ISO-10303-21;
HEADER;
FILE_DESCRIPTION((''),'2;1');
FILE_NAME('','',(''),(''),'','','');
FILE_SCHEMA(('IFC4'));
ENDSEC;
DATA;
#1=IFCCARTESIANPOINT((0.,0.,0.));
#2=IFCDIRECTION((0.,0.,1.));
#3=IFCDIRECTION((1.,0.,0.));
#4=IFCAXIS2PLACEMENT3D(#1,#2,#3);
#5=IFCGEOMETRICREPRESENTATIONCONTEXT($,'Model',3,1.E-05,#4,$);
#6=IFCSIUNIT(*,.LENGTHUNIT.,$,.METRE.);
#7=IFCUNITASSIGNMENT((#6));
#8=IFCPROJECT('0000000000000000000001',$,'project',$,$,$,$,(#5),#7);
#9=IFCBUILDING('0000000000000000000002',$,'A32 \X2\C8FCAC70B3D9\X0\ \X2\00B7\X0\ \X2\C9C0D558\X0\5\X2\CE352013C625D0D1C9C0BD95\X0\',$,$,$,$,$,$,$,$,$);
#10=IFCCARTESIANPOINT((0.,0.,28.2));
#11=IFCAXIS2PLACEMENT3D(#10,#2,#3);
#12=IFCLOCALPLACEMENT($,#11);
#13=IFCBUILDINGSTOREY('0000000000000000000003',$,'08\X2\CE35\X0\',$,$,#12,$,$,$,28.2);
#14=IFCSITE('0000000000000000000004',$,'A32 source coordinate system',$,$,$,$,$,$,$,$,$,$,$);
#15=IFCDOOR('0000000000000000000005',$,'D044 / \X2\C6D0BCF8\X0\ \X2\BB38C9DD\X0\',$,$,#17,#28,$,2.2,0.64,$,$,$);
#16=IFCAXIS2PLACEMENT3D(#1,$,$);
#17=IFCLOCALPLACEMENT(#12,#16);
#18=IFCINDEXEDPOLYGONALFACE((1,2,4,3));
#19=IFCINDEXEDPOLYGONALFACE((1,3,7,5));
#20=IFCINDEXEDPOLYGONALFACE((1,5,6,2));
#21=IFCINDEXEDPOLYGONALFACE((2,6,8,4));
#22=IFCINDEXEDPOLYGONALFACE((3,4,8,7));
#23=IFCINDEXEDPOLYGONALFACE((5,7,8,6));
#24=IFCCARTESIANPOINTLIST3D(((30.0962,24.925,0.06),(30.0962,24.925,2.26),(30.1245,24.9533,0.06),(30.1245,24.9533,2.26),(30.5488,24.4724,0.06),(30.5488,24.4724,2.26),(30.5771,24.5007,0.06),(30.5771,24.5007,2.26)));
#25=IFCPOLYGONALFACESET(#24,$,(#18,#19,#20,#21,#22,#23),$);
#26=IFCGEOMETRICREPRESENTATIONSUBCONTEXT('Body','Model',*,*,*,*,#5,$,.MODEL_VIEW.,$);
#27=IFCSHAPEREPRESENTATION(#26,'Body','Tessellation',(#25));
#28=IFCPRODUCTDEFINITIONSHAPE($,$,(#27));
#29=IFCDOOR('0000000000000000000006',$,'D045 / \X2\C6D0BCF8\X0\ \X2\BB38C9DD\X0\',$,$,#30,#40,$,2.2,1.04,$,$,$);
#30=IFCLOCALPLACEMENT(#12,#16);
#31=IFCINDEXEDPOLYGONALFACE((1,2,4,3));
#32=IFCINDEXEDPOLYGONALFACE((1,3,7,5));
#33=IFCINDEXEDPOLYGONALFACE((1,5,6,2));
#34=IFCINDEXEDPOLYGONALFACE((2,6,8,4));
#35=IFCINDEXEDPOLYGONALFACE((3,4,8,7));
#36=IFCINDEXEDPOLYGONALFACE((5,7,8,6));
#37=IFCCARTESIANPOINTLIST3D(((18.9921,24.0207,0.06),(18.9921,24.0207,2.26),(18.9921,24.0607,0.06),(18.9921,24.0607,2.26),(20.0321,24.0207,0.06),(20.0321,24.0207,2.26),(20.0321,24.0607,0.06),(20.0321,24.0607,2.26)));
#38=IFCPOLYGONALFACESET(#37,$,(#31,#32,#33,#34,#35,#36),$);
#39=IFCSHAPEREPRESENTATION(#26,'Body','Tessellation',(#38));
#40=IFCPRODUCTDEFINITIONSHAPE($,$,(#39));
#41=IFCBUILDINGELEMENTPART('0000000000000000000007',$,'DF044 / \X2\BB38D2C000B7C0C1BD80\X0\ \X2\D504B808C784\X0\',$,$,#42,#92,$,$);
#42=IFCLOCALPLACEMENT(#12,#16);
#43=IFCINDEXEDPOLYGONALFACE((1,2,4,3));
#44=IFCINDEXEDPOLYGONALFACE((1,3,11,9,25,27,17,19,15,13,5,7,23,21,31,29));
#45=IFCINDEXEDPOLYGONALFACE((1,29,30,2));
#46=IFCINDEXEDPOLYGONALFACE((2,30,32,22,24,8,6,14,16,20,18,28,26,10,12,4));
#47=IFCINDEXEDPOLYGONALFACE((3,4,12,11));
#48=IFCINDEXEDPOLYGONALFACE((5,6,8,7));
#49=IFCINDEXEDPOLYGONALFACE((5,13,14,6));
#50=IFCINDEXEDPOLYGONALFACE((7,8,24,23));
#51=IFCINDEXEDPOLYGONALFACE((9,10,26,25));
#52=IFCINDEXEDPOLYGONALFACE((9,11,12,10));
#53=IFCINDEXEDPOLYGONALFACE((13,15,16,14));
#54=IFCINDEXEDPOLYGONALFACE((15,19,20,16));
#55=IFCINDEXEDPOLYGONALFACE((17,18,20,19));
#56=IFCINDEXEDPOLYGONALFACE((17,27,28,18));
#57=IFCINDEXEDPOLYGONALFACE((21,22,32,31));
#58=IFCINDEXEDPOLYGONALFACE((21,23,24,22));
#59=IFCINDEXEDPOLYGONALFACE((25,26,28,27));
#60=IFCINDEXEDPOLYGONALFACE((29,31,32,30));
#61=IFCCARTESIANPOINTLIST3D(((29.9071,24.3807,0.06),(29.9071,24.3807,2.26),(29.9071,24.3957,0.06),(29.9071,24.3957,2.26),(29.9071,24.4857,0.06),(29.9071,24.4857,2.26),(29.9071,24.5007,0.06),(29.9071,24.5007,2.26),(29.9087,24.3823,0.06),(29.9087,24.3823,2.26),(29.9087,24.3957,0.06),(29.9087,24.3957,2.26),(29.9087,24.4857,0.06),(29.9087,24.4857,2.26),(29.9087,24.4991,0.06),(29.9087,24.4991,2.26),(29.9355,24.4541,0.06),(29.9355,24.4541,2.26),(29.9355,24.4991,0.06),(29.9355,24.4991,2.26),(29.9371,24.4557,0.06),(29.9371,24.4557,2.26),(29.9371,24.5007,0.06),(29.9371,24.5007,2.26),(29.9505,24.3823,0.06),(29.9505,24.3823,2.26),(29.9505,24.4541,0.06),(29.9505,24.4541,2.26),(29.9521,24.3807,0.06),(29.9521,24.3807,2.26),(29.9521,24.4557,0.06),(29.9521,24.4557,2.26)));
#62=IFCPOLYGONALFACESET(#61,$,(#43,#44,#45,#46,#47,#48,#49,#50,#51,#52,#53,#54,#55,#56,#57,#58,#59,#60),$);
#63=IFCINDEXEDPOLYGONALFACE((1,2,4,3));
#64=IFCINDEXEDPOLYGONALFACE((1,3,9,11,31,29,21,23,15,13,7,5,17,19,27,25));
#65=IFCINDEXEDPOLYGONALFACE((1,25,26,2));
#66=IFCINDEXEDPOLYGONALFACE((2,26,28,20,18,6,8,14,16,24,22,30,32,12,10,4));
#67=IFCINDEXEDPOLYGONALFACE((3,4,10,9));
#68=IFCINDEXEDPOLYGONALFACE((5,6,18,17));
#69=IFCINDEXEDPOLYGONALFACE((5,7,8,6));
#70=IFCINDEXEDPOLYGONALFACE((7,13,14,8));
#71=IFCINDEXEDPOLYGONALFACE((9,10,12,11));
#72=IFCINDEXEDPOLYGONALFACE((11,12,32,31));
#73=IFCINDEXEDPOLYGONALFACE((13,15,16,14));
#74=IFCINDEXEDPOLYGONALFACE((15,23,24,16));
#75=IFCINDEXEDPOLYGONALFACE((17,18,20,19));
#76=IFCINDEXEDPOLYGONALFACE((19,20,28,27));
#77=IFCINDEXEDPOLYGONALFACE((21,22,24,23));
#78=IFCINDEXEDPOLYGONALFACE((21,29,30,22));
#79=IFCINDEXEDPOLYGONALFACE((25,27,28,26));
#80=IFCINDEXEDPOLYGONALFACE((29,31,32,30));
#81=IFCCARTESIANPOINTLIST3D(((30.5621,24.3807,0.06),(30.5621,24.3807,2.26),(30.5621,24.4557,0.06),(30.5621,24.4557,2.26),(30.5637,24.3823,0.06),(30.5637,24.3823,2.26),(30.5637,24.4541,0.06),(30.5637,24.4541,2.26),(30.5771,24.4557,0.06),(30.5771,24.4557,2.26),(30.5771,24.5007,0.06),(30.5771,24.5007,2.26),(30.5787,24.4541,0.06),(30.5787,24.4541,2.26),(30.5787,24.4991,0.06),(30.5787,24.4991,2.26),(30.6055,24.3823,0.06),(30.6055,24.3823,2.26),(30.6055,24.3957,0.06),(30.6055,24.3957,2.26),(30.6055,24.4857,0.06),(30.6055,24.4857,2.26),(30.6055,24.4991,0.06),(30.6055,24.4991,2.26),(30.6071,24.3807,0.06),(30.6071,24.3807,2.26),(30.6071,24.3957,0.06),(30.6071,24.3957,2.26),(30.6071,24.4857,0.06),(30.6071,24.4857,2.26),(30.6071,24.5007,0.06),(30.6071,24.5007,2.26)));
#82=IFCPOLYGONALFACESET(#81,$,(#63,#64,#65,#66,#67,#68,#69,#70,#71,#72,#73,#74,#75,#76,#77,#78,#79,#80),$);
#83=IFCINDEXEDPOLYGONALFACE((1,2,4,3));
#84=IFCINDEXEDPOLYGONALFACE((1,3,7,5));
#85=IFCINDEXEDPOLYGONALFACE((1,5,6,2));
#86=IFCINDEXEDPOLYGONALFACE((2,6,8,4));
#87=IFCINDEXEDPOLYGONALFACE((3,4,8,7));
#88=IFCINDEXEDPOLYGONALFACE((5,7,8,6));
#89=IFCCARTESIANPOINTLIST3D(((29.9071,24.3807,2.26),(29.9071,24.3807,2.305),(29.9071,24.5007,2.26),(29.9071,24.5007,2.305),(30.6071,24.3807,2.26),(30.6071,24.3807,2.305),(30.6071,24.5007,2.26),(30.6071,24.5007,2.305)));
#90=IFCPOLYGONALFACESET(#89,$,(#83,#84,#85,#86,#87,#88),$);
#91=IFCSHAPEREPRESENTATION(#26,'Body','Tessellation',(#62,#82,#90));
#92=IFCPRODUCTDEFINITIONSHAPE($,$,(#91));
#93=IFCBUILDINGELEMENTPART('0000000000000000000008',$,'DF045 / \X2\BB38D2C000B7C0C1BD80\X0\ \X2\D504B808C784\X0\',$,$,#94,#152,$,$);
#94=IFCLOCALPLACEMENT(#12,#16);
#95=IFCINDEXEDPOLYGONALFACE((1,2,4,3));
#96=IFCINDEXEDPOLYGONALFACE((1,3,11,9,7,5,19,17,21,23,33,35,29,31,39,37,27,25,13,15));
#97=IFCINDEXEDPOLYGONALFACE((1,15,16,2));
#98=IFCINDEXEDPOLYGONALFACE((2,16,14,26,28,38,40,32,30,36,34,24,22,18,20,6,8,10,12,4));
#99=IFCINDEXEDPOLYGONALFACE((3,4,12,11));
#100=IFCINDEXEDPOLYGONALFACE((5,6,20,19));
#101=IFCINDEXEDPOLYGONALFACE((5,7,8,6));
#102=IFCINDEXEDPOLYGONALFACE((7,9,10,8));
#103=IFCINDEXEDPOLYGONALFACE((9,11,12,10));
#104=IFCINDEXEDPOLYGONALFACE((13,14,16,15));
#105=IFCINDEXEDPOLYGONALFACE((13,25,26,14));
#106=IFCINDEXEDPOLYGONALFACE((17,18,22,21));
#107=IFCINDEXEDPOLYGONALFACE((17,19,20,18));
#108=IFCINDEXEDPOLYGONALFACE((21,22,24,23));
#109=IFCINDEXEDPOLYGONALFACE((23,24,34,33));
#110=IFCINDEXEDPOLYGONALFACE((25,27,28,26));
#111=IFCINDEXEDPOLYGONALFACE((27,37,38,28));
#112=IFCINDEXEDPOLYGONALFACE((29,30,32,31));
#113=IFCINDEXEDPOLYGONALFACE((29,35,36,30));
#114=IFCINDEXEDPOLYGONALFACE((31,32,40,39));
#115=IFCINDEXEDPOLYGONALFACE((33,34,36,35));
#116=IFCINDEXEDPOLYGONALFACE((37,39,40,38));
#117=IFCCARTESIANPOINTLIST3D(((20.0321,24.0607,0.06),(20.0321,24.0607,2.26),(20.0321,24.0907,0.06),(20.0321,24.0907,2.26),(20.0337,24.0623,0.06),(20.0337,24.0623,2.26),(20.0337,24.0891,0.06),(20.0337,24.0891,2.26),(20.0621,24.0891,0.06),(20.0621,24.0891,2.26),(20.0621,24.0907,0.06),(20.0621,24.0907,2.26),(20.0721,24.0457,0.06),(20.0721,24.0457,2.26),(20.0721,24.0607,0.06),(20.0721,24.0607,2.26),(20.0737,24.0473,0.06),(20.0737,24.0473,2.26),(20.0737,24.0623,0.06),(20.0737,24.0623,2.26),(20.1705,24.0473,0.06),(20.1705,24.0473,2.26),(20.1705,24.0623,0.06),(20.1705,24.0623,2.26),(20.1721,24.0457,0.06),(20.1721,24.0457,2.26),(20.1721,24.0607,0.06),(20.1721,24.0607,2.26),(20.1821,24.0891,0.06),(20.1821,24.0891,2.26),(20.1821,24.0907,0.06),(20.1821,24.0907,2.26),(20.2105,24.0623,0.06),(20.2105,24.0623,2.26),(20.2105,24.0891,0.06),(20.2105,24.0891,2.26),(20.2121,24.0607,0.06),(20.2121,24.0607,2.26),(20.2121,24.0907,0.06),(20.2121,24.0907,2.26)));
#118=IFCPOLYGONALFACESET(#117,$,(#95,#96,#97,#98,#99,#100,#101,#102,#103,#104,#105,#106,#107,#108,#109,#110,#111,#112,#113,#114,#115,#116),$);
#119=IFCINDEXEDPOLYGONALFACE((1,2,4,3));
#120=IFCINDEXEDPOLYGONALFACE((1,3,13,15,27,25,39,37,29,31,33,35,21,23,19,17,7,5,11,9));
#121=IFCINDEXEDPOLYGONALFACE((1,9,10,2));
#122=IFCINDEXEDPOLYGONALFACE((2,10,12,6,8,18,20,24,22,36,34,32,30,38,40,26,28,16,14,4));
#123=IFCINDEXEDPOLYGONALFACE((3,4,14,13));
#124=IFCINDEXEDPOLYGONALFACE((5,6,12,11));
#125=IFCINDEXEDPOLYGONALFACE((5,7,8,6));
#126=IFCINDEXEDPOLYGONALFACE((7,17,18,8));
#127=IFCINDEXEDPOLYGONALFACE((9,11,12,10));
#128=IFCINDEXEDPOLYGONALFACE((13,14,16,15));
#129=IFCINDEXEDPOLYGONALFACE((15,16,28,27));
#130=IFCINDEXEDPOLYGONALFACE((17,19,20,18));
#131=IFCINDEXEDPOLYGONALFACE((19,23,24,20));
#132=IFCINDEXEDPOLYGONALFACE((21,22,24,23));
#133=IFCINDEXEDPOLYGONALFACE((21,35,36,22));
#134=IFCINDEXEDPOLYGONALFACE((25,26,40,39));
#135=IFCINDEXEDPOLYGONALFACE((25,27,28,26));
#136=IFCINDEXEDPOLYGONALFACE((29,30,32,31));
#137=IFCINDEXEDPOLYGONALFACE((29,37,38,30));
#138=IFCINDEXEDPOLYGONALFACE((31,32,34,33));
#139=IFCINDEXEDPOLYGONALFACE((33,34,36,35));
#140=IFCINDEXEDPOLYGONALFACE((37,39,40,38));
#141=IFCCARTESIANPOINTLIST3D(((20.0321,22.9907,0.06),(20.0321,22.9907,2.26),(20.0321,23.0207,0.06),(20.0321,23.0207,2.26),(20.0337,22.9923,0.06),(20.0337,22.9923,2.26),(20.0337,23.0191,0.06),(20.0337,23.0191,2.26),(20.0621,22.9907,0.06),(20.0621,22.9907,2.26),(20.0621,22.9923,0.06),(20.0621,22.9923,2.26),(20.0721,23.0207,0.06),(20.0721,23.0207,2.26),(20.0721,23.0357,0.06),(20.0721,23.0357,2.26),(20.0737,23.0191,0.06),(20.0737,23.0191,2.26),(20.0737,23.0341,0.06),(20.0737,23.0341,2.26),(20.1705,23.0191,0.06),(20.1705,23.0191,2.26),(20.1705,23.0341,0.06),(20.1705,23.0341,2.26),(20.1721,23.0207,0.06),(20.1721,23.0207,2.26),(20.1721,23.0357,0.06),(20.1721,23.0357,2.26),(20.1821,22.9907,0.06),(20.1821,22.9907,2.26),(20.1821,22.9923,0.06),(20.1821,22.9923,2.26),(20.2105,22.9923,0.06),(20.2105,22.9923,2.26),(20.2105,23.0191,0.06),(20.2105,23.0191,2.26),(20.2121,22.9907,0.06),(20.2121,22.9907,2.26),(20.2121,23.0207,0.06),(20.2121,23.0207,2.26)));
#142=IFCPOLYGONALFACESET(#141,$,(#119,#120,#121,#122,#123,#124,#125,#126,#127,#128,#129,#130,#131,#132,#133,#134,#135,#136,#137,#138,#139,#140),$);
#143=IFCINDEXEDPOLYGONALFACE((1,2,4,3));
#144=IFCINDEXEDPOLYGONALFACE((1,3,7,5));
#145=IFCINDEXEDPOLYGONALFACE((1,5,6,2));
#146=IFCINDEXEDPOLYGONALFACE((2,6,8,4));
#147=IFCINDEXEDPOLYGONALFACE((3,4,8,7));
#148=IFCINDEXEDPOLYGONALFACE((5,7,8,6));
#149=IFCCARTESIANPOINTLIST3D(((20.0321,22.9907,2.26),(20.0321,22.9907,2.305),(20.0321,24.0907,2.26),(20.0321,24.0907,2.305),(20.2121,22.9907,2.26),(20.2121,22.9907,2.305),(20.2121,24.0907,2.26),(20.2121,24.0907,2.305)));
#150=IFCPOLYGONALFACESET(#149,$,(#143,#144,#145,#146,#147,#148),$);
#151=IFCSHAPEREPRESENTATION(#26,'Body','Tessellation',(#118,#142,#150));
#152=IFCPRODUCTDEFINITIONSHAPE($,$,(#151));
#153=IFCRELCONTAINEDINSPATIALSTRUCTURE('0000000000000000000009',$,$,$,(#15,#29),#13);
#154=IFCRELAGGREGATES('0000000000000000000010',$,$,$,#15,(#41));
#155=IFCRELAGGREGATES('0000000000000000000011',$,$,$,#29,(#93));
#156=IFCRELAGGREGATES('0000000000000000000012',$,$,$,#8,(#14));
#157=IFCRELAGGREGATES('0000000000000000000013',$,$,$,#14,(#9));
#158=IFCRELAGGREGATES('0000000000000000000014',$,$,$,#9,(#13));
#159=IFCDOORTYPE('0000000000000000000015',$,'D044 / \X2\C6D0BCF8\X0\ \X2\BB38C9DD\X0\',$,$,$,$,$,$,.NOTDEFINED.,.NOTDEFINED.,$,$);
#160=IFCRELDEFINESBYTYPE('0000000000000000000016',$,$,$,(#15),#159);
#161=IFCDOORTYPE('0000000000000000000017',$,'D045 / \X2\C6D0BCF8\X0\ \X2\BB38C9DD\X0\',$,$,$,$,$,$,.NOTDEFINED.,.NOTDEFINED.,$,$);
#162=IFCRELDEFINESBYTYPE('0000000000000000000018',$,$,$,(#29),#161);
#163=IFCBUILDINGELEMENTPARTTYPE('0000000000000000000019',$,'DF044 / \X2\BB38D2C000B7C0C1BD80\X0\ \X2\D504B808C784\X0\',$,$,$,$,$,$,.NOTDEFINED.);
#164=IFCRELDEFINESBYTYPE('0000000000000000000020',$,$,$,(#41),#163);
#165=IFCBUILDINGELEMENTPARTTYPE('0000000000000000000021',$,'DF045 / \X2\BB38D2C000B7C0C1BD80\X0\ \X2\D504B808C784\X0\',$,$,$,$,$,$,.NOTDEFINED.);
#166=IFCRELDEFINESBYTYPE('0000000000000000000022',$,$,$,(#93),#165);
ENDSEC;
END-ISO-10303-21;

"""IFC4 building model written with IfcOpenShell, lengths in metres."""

from ifc_helpers import new_model, si_unit, frame, origin, origin_with_axes, place, context, subcontext, project, spatial, polyline, outline, extrude, source, transform, mapped, type_object, type_shapes, element, aggregate, save


model = new_model("IFC4")

# Units and contexts
model_context = context("Model", 3, precision=1e-05, world=origin_with_axes())
body_context = subcontext(model_context, "Body", "Model", "MODEL_VIEW")
ifc_project = project(units=[si_unit("LENGTHUNIT", "METRE")], contexts=[model_context])

# Site, building, storey
storey_placement = place(None, frame((0.0, 0.0, 28.2), z_axis=(0.0, 0.0, 1.0), x_axis=(1.0, 0.0, 0.0)))
site = spatial("IfcSite", under=ifc_project, Name="A32 source coordinate system")
building = spatial("IfcBuilding", under=site, Name="A32 주거동 · 지하5층–옥탑지붕")
storey = spatial("IfcBuildingStorey", under=building, at=storey_placement, Name="08층", Elevation=28.2)

# Doors
door_type_1 = type_object("IfcDoorType", Name="D044 / 원본 문짝", OperationType="NOTDEFINED", PredefinedType="NOTDEFINED")
shared_shape_1 = source(origin(), body_context, "Body", "SweptSolid", [
    extrude(outline(polyline([(30.5771, 24.5007), (30.5488, 24.4724), (30.0962, 24.925), (30.1245, 24.9533), (30.5771, 24.5007)])), frame((0.0, 0.0, 0.06)), (0.0, 0.0, 1.0), 2.2),
])
type_shapes(door_type_1, [shared_shape_1])
door_1_placement = place(storey_placement, origin_with_axes())
door_1 = element("IfcDoor", 1, at=door_1_placement, inside=storey, type_object=door_type_1, Name="D044 / 원본 문짝", OverallHeight=2.2, OverallWidth=0.64, context=body_context, shape_type="MappedRepresentation", body=[
    mapped(shared_shape_1, transform((0.0, 0.0, 0.0), scale=1.0)),
])
door_type_2 = type_object("IfcDoorType", Name="D045 / 원본 문짝", OperationType="NOTDEFINED", PredefinedType="NOTDEFINED")
shared_shape_2 = source(origin(), body_context, "Body", "SweptSolid", [
    extrude(outline(polyline([(20.0321, 24.0607), (20.0321, 24.0207), (18.9921, 24.0207), (18.9921, 24.0607), (20.0321, 24.0607)])), frame((0.0, 0.0, 0.06)), (0.0, 0.0, 1.0), 2.2),
])
type_shapes(door_type_2, [shared_shape_2])
door_2_placement = place(storey_placement, origin_with_axes())
door_2 = element("IfcDoor", 2, at=door_2_placement, inside=storey, type_object=door_type_2, Name="D045 / 원본 문짝", OverallHeight=2.2, OverallWidth=1.04, context=body_context, shape_type="MappedRepresentation", body=[
    mapped(shared_shape_2, transform((0.0, 0.0, 0.0), scale=1.0)),
])

# Building element parts
building_element_part_type_1 = type_object("IfcBuildingElementPartType", Name="DF044 / 문틀·상부 프레임", PredefinedType="NOTDEFINED")
shared_shape_3 = source(origin(), body_context, "Body", "SweptSolid", [
    extrude(outline(polyline([(29.9071, 24.4857), (29.9071, 24.5007), (29.9371, 24.5007), (29.9371, 24.4557), (29.9521, 24.4557), (29.9521, 24.3807), (29.9071, 24.3807), (29.9071, 24.3957), (29.9087, 24.3957), (29.9087, 24.3823), (29.9505, 24.3823), (29.9505, 24.4541), (29.9355, 24.4541), (29.9355, 24.4991), (29.9087, 24.4991), (29.9087, 24.4857), (29.9071, 24.4857)])), frame((0.0, 0.0, 0.06)), (0.0, 0.0, 1.0), 2.2),
    extrude(outline(polyline([(30.6055, 24.4991), (30.5787, 24.4991), (30.5787, 24.4541), (30.5637, 24.4541), (30.5637, 24.3823), (30.6055, 24.3823), (30.6055, 24.3957), (30.6071, 24.3957), (30.6071, 24.3807), (30.5621, 24.3807), (30.5621, 24.4557), (30.5771, 24.4557), (30.5771, 24.5007), (30.6071, 24.5007), (30.6071, 24.4857), (30.6055, 24.4857), (30.6055, 24.4991)])), frame((0.0, 0.0, 0.06)), (0.0, 0.0, 1.0), 2.2),
    extrude(outline(polyline([(29.9071, 24.3807), (29.9071, 24.5007), (30.6071, 24.5007), (30.6071, 24.3807), (29.9071, 24.3807)])), frame((0.0, 0.0, 2.26)), (0.0, 0.0, 1.0), 0.045),
])
type_shapes(building_element_part_type_1, [shared_shape_3])
building_element_part_1_placement = place(door_1_placement, origin_with_axes())
building_element_part_1 = element("IfcBuildingElementPart", 3, at=building_element_part_1_placement, type_object=building_element_part_type_1, Name="DF044 / 문틀·상부 프레임", context=body_context, shape_type="MappedRepresentation", body=[
    mapped(shared_shape_3, transform((0.0, 0.0, 0.0), scale=1.0)),
])
aggregate(door_1, [building_element_part_1])
building_element_part_type_2 = type_object("IfcBuildingElementPartType", Name="DF045 / 문틀·상부 프레임", PredefinedType="NOTDEFINED")
shared_shape_4 = source(origin(), body_context, "Body", "SweptSolid", [
    extrude(outline(polyline([(20.0337, 24.0891), (20.0337, 24.0623), (20.0737, 24.0623), (20.0737, 24.0473), (20.1705, 24.0473), (20.1705, 24.0623), (20.2105, 24.0623), (20.2105, 24.0891), (20.1821, 24.0891), (20.1821, 24.0907), (20.2121, 24.0907), (20.2121, 24.0607), (20.1721, 24.0607), (20.1721, 24.0457), (20.0721, 24.0457), (20.0721, 24.0607), (20.0321, 24.0607), (20.0321, 24.0907), (20.0621, 24.0907), (20.0621, 24.0891), (20.0337, 24.0891)])), frame((0.0, 0.0, 0.06)), (0.0, 0.0, 1.0), 2.2),
    extrude(outline(polyline([(20.0621, 22.9907), (20.0321, 22.9907), (20.0321, 23.0207), (20.0721, 23.0207), (20.0721, 23.0357), (20.1721, 23.0357), (20.1721, 23.0207), (20.2121, 23.0207), (20.2121, 22.9907), (20.1821, 22.9907), (20.1821, 22.9923), (20.2105, 22.9923), (20.2105, 23.0191), (20.1705, 23.0191), (20.1705, 23.0341), (20.0737, 23.0341), (20.0737, 23.0191), (20.0337, 23.0191), (20.0337, 22.9923), (20.0621, 22.9923), (20.0621, 22.9907)])), frame((0.0, 0.0, 0.06)), (0.0, 0.0, 1.0), 2.2),
    extrude(outline(polyline([(20.0321, 22.9907), (20.0321, 24.0907), (20.2121, 24.0907), (20.2121, 22.9907), (20.0321, 22.9907)])), frame((0.0, 0.0, 2.26)), (0.0, 0.0, 1.0), 0.045),
])
type_shapes(building_element_part_type_2, [shared_shape_4])
building_element_part_2_placement = place(door_2_placement, origin_with_axes())
building_element_part_2 = element("IfcBuildingElementPart", 4, at=building_element_part_2_placement, type_object=building_element_part_type_2, Name="DF045 / 문틀·상부 프레임", context=body_context, shape_type="MappedRepresentation", body=[
    mapped(shared_shape_4, transform((0.0, 0.0, 0.0), scale=1.0)),
])
aggregate(door_2, [building_element_part_2])

save(model, "model.ifc")
